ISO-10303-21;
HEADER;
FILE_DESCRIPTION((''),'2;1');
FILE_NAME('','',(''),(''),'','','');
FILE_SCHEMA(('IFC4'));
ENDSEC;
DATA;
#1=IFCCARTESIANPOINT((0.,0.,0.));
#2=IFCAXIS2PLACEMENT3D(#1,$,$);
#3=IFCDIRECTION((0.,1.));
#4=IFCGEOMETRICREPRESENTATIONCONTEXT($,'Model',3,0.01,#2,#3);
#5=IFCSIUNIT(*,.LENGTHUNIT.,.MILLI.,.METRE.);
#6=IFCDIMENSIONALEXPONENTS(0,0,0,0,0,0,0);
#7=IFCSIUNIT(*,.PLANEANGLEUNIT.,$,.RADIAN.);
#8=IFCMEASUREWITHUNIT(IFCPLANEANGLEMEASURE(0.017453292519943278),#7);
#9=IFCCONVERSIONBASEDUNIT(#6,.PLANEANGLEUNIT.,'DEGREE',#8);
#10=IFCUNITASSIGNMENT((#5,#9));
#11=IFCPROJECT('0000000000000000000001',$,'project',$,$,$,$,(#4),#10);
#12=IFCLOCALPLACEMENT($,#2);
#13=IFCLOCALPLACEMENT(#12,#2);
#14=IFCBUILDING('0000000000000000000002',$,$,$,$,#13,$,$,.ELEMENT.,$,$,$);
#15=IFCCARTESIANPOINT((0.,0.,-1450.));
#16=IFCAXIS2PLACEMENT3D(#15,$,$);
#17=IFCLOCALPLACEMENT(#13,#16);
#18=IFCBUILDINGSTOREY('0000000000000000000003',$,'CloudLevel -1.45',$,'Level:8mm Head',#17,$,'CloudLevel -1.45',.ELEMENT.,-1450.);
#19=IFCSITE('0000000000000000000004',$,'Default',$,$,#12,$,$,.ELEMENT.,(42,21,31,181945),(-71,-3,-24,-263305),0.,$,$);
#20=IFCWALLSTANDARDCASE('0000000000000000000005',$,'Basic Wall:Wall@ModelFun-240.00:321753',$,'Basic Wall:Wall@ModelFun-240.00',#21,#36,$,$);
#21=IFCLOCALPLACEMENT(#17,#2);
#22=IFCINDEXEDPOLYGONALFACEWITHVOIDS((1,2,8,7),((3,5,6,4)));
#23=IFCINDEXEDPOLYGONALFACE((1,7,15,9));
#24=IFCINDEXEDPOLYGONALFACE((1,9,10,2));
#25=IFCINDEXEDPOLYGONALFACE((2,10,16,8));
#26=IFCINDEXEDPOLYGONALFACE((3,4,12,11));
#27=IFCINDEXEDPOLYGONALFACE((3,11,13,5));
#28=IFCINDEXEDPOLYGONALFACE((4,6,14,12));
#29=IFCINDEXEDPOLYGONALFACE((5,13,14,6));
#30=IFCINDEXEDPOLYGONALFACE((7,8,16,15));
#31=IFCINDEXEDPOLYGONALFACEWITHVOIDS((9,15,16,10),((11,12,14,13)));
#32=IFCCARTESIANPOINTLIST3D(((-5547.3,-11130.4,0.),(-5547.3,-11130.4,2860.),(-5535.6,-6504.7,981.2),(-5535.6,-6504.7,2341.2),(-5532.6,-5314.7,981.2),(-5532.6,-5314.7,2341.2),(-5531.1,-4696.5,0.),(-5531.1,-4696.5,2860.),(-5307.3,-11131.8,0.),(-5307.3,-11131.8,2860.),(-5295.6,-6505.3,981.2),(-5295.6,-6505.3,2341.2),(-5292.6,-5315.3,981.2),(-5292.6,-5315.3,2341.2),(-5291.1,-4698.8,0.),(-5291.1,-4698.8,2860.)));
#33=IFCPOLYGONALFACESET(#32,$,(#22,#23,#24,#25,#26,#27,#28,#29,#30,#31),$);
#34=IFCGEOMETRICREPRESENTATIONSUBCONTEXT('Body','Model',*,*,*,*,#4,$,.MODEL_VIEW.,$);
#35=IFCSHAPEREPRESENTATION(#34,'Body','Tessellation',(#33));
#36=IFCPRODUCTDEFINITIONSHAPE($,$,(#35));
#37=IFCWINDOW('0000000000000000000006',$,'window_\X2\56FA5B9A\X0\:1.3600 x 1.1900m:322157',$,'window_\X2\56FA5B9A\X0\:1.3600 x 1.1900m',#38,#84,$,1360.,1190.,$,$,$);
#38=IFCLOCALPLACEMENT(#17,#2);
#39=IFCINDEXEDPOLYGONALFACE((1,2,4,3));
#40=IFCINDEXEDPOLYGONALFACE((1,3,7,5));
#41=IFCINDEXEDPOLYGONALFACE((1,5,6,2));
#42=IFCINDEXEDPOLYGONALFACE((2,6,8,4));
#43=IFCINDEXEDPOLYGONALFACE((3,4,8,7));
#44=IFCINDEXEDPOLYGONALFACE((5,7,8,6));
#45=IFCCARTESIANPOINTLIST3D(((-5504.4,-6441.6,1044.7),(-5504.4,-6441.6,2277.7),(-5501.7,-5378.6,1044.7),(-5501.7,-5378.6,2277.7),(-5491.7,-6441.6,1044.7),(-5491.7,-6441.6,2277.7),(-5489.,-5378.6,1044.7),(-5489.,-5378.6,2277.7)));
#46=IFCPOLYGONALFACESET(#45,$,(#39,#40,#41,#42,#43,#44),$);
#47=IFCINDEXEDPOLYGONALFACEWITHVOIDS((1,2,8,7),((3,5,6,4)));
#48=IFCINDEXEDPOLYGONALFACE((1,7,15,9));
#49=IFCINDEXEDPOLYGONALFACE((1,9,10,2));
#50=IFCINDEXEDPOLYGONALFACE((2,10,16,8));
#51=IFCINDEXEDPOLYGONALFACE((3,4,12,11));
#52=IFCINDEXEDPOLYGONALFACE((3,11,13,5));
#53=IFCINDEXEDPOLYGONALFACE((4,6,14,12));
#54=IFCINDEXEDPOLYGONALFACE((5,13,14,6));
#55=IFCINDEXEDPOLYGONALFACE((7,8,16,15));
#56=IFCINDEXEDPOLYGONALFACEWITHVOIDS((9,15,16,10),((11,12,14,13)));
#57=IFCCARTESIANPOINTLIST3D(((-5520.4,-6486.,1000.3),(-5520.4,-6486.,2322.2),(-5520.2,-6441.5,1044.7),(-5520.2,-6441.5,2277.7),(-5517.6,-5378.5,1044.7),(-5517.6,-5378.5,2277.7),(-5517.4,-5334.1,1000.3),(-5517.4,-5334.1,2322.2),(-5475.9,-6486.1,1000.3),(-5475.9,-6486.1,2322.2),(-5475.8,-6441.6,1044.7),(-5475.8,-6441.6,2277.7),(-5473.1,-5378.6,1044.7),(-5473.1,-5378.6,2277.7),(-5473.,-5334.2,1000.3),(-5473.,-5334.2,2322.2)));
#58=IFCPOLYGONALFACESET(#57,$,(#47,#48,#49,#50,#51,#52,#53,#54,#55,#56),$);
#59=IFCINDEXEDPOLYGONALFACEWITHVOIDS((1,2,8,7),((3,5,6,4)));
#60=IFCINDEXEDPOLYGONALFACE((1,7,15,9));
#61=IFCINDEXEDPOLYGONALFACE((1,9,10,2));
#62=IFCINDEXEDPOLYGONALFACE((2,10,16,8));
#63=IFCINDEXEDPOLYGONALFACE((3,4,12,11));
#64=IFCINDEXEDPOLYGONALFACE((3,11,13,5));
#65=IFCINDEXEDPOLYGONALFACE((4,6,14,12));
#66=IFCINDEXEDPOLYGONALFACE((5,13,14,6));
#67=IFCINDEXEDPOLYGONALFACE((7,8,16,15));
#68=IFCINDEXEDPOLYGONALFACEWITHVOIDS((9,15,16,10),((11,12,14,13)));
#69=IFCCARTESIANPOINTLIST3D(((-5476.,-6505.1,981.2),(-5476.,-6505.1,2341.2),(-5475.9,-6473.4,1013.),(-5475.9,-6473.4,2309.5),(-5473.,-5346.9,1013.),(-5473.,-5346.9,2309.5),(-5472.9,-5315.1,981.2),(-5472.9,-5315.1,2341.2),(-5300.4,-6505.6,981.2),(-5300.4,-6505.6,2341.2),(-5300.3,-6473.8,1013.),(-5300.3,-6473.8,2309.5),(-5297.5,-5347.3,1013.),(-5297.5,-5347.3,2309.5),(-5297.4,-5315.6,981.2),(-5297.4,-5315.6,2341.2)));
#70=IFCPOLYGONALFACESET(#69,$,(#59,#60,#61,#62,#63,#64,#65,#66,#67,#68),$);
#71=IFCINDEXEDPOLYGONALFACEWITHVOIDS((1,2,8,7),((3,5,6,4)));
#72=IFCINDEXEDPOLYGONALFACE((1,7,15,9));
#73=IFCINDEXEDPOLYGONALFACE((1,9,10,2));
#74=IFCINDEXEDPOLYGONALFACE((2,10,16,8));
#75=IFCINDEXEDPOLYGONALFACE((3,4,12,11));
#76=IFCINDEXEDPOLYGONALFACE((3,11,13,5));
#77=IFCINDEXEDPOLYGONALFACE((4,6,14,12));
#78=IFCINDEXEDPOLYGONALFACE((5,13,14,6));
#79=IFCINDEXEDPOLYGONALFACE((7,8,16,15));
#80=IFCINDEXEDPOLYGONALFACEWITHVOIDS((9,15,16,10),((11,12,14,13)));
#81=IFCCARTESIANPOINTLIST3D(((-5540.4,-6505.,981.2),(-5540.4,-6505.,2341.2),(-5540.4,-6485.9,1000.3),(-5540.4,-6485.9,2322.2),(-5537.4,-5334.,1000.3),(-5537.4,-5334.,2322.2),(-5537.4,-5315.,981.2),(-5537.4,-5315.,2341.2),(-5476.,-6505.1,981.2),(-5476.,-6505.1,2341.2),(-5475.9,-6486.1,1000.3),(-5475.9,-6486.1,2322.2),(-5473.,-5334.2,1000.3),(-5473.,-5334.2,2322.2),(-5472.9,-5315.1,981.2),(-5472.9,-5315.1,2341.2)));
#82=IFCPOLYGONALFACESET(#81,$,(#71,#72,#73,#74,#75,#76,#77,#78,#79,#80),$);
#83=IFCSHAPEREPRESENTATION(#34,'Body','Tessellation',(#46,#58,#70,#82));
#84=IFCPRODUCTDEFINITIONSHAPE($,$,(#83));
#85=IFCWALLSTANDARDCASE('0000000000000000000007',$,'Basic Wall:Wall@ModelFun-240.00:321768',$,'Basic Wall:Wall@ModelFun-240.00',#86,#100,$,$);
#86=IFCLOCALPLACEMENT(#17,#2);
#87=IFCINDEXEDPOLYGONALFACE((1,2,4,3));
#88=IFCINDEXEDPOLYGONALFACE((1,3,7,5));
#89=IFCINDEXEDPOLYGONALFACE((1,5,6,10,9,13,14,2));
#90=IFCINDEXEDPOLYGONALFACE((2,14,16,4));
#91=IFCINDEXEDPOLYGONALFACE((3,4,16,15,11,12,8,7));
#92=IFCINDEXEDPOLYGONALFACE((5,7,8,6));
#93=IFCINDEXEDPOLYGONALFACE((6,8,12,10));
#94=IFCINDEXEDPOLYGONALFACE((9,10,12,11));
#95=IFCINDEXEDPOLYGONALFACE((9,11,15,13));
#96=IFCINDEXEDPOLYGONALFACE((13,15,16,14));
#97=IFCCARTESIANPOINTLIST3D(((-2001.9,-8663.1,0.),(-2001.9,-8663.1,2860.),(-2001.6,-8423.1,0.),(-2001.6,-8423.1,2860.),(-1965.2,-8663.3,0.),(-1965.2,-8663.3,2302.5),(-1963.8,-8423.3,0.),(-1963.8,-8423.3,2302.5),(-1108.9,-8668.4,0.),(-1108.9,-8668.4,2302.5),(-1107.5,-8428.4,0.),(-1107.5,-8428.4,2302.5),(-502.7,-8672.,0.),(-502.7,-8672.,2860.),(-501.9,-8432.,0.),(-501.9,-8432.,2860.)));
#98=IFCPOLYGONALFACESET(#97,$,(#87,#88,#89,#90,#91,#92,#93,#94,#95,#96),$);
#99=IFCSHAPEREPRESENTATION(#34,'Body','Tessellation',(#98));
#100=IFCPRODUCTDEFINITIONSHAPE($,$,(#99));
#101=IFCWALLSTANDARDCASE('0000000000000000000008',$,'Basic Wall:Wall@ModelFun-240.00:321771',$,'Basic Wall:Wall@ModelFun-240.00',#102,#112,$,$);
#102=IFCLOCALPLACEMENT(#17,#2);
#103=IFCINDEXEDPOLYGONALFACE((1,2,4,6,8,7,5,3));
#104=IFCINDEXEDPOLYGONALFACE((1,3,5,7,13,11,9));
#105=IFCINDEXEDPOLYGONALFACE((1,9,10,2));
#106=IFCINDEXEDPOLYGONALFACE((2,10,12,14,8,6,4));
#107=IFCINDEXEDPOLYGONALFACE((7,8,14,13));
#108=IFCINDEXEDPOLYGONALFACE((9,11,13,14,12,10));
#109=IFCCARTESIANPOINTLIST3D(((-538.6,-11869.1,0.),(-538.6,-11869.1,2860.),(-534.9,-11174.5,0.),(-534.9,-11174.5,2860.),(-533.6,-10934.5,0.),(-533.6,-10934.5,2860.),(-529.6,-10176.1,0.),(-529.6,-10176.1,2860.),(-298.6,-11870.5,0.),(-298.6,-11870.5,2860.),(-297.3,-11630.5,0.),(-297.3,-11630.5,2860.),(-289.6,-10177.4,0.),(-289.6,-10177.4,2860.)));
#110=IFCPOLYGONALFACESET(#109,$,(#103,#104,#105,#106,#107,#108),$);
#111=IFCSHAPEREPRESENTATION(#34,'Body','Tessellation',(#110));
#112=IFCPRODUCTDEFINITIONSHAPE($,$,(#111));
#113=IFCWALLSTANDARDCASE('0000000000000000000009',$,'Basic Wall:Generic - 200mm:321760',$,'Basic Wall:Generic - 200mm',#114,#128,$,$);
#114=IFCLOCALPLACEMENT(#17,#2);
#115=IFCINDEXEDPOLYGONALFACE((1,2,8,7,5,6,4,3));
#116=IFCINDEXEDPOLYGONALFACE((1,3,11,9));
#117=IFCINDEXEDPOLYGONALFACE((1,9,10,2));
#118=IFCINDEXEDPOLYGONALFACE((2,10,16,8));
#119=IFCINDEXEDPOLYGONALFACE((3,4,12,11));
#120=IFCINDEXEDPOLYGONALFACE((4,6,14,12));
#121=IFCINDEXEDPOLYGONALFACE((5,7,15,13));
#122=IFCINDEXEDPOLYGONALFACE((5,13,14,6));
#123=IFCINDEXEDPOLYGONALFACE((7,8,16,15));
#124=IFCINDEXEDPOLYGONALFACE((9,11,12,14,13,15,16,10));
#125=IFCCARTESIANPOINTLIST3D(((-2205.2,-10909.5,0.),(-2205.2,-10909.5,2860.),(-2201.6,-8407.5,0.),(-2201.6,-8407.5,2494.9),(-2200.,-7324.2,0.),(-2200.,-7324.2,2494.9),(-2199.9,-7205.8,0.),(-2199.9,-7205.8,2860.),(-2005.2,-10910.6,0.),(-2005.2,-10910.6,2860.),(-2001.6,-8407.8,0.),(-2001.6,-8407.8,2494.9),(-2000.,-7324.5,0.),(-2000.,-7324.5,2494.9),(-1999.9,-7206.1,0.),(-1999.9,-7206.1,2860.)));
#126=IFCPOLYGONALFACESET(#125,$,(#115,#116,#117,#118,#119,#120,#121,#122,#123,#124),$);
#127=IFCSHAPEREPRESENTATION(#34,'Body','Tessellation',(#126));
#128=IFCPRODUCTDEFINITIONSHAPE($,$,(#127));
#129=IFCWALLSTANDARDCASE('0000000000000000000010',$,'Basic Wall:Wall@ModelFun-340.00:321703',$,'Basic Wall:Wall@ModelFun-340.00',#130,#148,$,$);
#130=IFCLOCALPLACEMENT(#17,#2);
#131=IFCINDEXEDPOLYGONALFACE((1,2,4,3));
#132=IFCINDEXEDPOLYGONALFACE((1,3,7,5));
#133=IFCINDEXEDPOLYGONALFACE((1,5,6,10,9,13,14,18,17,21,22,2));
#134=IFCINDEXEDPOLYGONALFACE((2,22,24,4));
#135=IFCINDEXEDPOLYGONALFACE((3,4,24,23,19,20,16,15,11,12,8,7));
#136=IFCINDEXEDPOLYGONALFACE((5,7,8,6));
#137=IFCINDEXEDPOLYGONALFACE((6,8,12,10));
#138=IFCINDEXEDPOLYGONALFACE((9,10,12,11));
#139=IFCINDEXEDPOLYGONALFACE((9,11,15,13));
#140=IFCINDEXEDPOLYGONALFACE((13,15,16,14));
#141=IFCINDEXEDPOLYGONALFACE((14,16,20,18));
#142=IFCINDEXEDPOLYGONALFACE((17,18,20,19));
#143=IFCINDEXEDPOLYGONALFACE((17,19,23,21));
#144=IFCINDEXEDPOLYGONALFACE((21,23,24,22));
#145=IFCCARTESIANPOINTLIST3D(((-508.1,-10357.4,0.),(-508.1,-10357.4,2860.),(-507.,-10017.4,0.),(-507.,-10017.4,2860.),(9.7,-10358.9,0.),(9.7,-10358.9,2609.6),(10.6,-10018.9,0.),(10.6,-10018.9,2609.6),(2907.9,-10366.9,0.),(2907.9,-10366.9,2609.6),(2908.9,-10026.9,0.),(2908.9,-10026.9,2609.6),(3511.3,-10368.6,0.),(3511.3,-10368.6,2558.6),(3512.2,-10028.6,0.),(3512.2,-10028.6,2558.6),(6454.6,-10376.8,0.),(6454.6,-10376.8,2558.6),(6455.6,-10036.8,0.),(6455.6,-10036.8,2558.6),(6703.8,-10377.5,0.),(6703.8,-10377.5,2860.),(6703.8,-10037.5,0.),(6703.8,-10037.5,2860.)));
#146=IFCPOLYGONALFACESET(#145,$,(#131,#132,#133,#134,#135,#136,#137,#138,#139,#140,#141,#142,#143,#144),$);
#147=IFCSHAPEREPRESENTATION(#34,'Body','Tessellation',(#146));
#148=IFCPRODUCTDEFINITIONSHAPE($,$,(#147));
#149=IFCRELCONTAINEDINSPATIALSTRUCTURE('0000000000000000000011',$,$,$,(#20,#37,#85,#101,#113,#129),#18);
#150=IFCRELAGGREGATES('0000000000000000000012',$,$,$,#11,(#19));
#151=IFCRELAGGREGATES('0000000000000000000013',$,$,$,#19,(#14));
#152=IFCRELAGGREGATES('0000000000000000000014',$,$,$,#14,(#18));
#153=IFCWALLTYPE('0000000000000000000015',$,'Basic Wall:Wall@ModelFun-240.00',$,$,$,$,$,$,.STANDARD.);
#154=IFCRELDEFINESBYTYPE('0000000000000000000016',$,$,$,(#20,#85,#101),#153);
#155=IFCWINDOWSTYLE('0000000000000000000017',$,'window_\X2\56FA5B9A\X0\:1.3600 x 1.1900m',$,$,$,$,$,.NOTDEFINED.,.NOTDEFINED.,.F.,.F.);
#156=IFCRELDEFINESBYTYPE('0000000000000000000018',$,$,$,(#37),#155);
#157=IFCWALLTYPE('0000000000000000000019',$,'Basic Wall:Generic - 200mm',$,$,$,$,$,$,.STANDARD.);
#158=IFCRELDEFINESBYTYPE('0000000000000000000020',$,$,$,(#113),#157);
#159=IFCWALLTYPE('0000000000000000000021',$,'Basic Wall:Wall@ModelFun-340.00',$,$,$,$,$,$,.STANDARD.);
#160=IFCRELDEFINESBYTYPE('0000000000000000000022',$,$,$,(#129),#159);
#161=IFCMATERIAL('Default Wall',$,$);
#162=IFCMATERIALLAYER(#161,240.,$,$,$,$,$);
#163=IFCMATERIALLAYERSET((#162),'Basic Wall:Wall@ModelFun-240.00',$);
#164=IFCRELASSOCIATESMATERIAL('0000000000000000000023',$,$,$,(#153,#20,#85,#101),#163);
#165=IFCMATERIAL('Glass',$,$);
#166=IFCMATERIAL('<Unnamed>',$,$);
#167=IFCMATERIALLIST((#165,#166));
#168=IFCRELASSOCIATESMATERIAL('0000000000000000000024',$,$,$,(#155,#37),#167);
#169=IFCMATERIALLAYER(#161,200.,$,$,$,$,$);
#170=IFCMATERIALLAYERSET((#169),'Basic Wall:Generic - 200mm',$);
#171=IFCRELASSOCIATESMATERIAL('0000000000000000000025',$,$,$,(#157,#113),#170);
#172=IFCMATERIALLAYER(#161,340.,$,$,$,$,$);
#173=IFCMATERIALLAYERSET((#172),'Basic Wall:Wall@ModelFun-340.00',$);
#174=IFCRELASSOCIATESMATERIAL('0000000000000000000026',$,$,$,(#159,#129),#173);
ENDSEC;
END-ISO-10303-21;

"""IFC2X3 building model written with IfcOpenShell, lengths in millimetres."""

from ifc_helpers import new_model, entity, si_unit, converted_unit, direction, frame, frame_2d, origin, place, context, subcontext, project, spatial, polyline, rectangle, outline, extrude, source, transform, mapped, material, material_list, layer, layer_set, layer_usage, type_object, type_shapes, element, fill, save


model = new_model("IFC2X3")

# Units and contexts
model_context = context("Model", 3, precision=0.01, world=origin(), true_north=direction((0.0, 1.0)))
body_context = subcontext(model_context, "Body", "Model", "MODEL_VIEW")
ifc_project = project(units=[si_unit("LENGTHUNIT", "METRE", prefix="MILLI"), converted_unit("PLANEANGLEUNIT", "DEGREE", entity("IfcPlaneAngleMeasure", 0.017453292519943278), si_unit("PLANEANGLEUNIT", "RADIAN"), dimensions=[0, 0, 0, 0, 0, 0, 0])], contexts=[model_context])

# Site, building, storey
site_placement = place(None, origin())
site = spatial("IfcSite", under=ifc_project, at=site_placement, Name="Default", CompositionType="ELEMENT", RefLatitude=(42, 21, 31, 181945), RefLongitude=(-71, -3, -24, -263305), RefElevation=0.0)
building_placement = place(site_placement, origin())
building = spatial("IfcBuilding", under=site, at=building_placement, CompositionType="ELEMENT")
storey_placement = place(building_placement, frame((0.0, 0.0, -1450.0)))
storey = spatial("IfcBuildingStorey", under=building, at=storey_placement, Name="CloudLevel -1.45", ObjectType="Level:8mm Head", LongName="CloudLevel -1.45", CompositionType="ELEMENT", Elevation=-1450.0)

# Wall, opening, window
ifc_material_1 = material(Name="Default Wall")
ifc_layer_1 = layer(ifc_material_1, 240.0)
ifc_layer_set_1 = layer_set([ifc_layer_1], Name="Basic Wall:Wall@ModelFun-240.00")
ifc_layer_usage_1 = layer_usage(ifc_layer_set_1, "AXIS2", "NEGATIVE", 120.0)
wall_type_1 = type_object("IfcWallType", Name="Basic Wall:Wall@ModelFun-240.00", PredefinedType="STANDARD", material=ifc_layer_set_1)
ifc_material_2 = material(Name="Glass")
ifc_material_3 = material(Name="<Unnamed>")
ifc_material_list = material_list([ifc_material_2, ifc_material_3])
wall_1_placement = place(storey_placement, frame((-5411.1, -4696.8, 0.0), z_axis=(0.0, 0.0, 1.0), x_axis=(-0.002529, -0.999997, 0.0)))
wall_1 = element("IfcWallStandardCase", 1, at=wall_1_placement, inside=storey, type_object=wall_type_1, material=ifc_layer_usage_1, Name="Basic Wall:Wall@ModelFun-240.00:321753", ObjectType="Basic Wall:Wall@ModelFun-240.00", context=body_context, shape_type="SweptSolid", body=[
    extrude(outline(polyline([(6434.0, -120.0), (6434.7, 120.0), (6194.7, 120.0), (2564.7, 120.0), (2404.7, 120.0), (1.7, 120.0), (0.0, -120.0), (6434.0, -120.0)])), origin(), (0.0, 0.0, 1.0), 2860.0),
])
opening_1_placement = place(wall_1_placement, frame((1808.2, 120.0, 981.2)))
opening_1 = element("IfcOpeningElement", 2, at=opening_1_placement, cuts=wall_1, ObjectType="Opening", context=body_context, shape_type="SweptSolid", body=[
    extrude(rectangle(XDim=1360.0, YDim=1190.0, at=frame_2d((680.0, 595.0), x_axis=(-1.0, 0.0))), frame((0.0, 0.0, 0.0), z_axis=(0.0, -1.0, 0.0), x_axis=(0.0, 0.0, 1.0)), (0.0, 0.0, 1.0), 240.0),
])
window_style_1 = type_object("IfcWindowStyle", Name="window_固定:1.3600 x 1.1900m", ConstructionType="NOTDEFINED", OperationType="NOTDEFINED", ParameterTakesPrecedence=False, Sizeable=False, material=ifc_material_list)
shared_shape_1 = source(origin(), body_context, "Body", "SweptSolid", [
    extrude(rectangle(XDim=1063.0, YDim=12.7, at=frame_2d((0.0, 0.0), x_axis=(1.0, 0.0))), frame((671.2, 197.8, 63.5)), (0.0, 0.0, 1.0), 1233.0),
    extrude(outline(polyline([(-575.9, -660.9), (575.9, -660.9), (575.9, 660.9), (-575.9, 660.9), (-575.9, -660.9)]), holes=[polyline([(-531.5, -616.5), (-531.5, 616.5), (531.5, 616.5), (531.5, -616.5), (-531.5, -616.5)])]), frame((671.2, 220.0, 680.0), z_axis=(0.0, -1.0, 0.0), x_axis=(-1.0, 0.0, 0.0)), (0.0, 0.0, 1.0), 44.4),
    extrude(outline(polyline([(-595.0, -680.0), (595.0, -680.0), (595.0, 680.0), (-595.0, 680.0), (-595.0, -680.0)]), holes=[polyline([(-563.2, -648.2), (-563.2, 648.2), (563.2, 648.2), (563.2, -648.2), (-563.2, -648.2)])]), frame((671.2, 175.5, 680.0), z_axis=(0.0, -1.0, 0.0), x_axis=(-1.0, 0.0, 0.0)), (0.0, 0.0, 1.0), 175.5),
    extrude(outline(polyline([(-680.0, -595.0), (680.0, -595.0), (680.0, 595.0), (-680.0, 595.0), (-680.0, -595.0)]), holes=[polyline([(-660.9, -575.9), (-660.9, 575.9), (660.9, 575.9), (660.9, -575.9), (-660.9, -575.9)])]), frame((671.2, 240.0, 680.0), z_axis=(0.0, -1.0, 0.0), x_axis=(0.0, 0.0, -1.0)), (0.0, 0.0, 1.0), 64.4),
])
type_shapes(window_style_1, [shared_shape_1])
window_1_placement = place(opening_1_placement, frame((76.5, -4.8, 0.0), z_axis=(0.0, 0.0, 1.0), x_axis=(-1.0, 0.0, 0.0)))
window_1 = element("IfcWindow", 3, at=window_1_placement, inside=storey, type_object=window_style_1, material=ifc_material_list, Name="window_固定:1.3600 x 1.1900m:322157", ObjectType="window_固定:1.3600 x 1.1900m", OverallHeight=1360.0, OverallWidth=1190.0, context=body_context, shape_type="MappedRepresentation", body=[
    mapped(shared_shape_1, transform((0.0, 0.0, 0.0), scale=1.0)),
])
fill(opening_1, window_1)

# Wall, opening
wall_2_placement = place(storey_placement, frame((-2002.3, -8543.1, 0.0), z_axis=(0.0, 0.0, 1.0), x_axis=(0.999983, -0.005913, 0.0)))
wall_2 = element("IfcWallStandardCase", 4, at=wall_2_placement, inside=storey, type_object=wall_type_1, material=ifc_layer_usage_1, Name="Basic Wall:Wall@ModelFun-240.00:321768", ObjectType="Basic Wall:Wall@ModelFun-240.00", context=body_context, shape_type="SweptSolid", body=[
    extrude(outline(polyline([(1.1, -120.0), (1500.4, -120.0), (1499.7, 120.0), (0.0, 120.0), (1.1, -120.0)])), origin(), (0.0, 0.0, 1.0), 2860.0),
])
opening_2_placement = place(wall_2_placement, frame((37.8, -120.0, 0.0)))
element("IfcOpeningElement", 5, at=opening_2_placement, cuts=wall_2, ObjectType="Opening", context=body_context, shape_type="SweptSolid", body=[
    extrude(rectangle(XDim=856.3, YDim=2302.5, at=frame_2d((1151.3, 428.1), x_axis=(0.0, 1.0))), frame((0.0, 0.0, 0.0), z_axis=(0.0, 1.0, 0.0), x_axis=(0.0, 0.0, 1.0)), (0.0, 0.0, 1.0), 240.0),
])

# Wall
wall_3_placement = place(storey_placement, frame((-418.6, -11869.9, 0.0), z_axis=(0.0, 0.0, 1.0), x_axis=(0.005277, 0.999986, 0.0)))
element("IfcWallStandardCase", 6, at=wall_3_placement, inside=storey, type_object=wall_type_1, material=ifc_layer_usage_1, Name="Basic Wall:Wall@ModelFun-240.00:321771", ObjectType="Basic Wall:Wall@ModelFun-240.00", context=body_context, shape_type="SweptSolid", body=[
    extrude(outline(polyline([(1693.2, -120.0), (1693.2, 120.0), (934.8, 120.0), (694.8, 120.0), (0.2, 120.0), (0.0, -120.0), (240.0, -120.0), (1693.2, -120.0)])), origin(), (0.0, 0.0, 1.0), 2860.0),
])

# Walls, openings
ifc_layer_2 = layer(ifc_material_1, 200.0)
ifc_layer_set_2 = layer_set([ifc_layer_2], Name="Basic Wall:Generic - 200mm")
ifc_layer_usage_2 = layer_usage(ifc_layer_set_2, "AXIS2", "NEGATIVE", 100.0)
wall_type_2 = type_object("IfcWallType", Name="Basic Wall:Generic - 200mm", PredefinedType="STANDARD", material=ifc_layer_set_2)
wall_4_placement = place(storey_placement, frame((-2105.2, -10910.5, 0.0), z_axis=(0.0, 0.0, 1.0), x_axis=(0.001425, 0.999999, 0.0)))
wall_4 = element("IfcWallStandardCase", 7, at=wall_4_placement, inside=storey, type_object=wall_type_2, material=ifc_layer_usage_2, Name="Basic Wall:Generic - 200mm:321760", ObjectType="Basic Wall:Generic - 200mm", context=body_context, shape_type="SweptSolid", body=[
    extrude(outline(polyline([(0.0, -100.0), (2247.5, -100.0), (2487.5, -100.0), (3704.5, -100.0), (3704.5, 100.0), (0.9, 100.0), (0.0, -100.0)])), origin(), (0.0, 0.0, 1.0), 2860.0),
])
opening_3_placement = place(wall_4_placement, frame((0.0, 0.0, 0.0), z_axis=(0.0, 0.0, 1.0), x_axis=(0.999999, 0.001425, 0.0)))
element("IfcOpeningElement", 8, at=opening_3_placement, cuts=wall_4, ObjectType="Opening", context=body_context, shape_type="SweptSolid", body=[
    extrude(rectangle(XDim=1960.0, YDim=240.0, at=frame_2d((0.0, 0.0), x_axis=(0.0, 1.0))), frame((-141.6, -1360.9, 1367.5), z_axis=(0.00064, 1.0, 0.0), x_axis=(-1.0, 0.00064, 0.0)), (0.0, 0.0, 1.0), 1390.0),
])
opening_4_placement = place(wall_4_placement, frame((2502.8, -100.0, 0.0)))
element("IfcOpeningElement", 9, at=opening_4_placement, cuts=wall_4, ObjectType="Opening", context=body_context, shape_type="SweptSolid", body=[
    extrude(rectangle(XDim=1083.4, YDim=2494.9, at=frame_2d((1247.5, 541.7), x_axis=(0.0, 1.0))), frame((0.0, 0.0, 0.0), z_axis=(0.0, 1.0, 0.0), x_axis=(0.0, 0.0, 1.0)), (0.0, 0.0, 1.0), 200.0),
])
ifc_layer_3 = layer(ifc_material_1, 340.0)
ifc_layer_set_3 = layer_set([ifc_layer_3], Name="Basic Wall:Wall@ModelFun-340.00")
ifc_layer_usage_3 = layer_usage(ifc_layer_set_3, "AXIS2", "NEGATIVE", 170.0)
wall_type_3 = type_object("IfcWallType", Name="Basic Wall:Wall@ModelFun-340.00", PredefinedType="STANDARD", material=ifc_layer_set_3)
wall_5_placement = place(storey_placement, frame((-507.6, -10187.4, 0.0), z_axis=(0.0, 0.0, 1.0), x_axis=(0.999996, -0.002782, 0.0)))
wall_5 = element("IfcWallStandardCase", 10, at=wall_5_placement, inside=storey, type_object=wall_type_3, material=ifc_layer_usage_3, Name="Basic Wall:Wall@ModelFun-340.00:321703", ObjectType="Basic Wall:Wall@ModelFun-340.00", context=body_context, shape_type="SweptSolid", body=[
    extrude(outline(polyline([(0.0, -170.0), (3583.2, -170.0), (3823.3, -170.0), (7211.9, -170.0), (7211.0, 170.0), (3816.4, 170.0), (3606.4, 170.0), (210.1, 170.0), (0.1, 170.0), (0.0, -170.0)])), origin(), (0.0, 0.0, 1.0), 2860.0),
])
opening_5_placement = place(wall_5_placement, frame((517.8, -170.0, 0.0)))
element("IfcOpeningElement", 11, at=opening_5_placement, cuts=wall_5, ObjectType="Opening", context=body_context, shape_type="SweptSolid", body=[
    extrude(rectangle(XDim=2609.6, YDim=2898.3, at=frame_2d((1304.8, 1449.1), x_axis=(1.0, 0.0))), frame((0.0, 0.0, 0.0), z_axis=(0.0, 1.0, 0.0), x_axis=(0.0, 0.0, 1.0)), (0.0, 0.0, 1.0), 340.0),
])
opening_6_placement = place(wall_5_placement, frame((4019.4, -170.0, 0.0)))
element("IfcOpeningElement", 12, at=opening_6_placement, cuts=wall_5, ObjectType="Opening", context=body_context, shape_type="SweptSolid", body=[
    extrude(rectangle(XDim=2558.6, YDim=2943.4, at=frame_2d((1279.3, 1471.7), x_axis=(1.0, 0.0))), frame((0.0, 0.0, 0.0), z_axis=(0.0, 1.0, 0.0), x_axis=(0.0, 0.0, 1.0)), (0.0, 0.0, 1.0), 340.0),
])

save(model, "model.ifc")
